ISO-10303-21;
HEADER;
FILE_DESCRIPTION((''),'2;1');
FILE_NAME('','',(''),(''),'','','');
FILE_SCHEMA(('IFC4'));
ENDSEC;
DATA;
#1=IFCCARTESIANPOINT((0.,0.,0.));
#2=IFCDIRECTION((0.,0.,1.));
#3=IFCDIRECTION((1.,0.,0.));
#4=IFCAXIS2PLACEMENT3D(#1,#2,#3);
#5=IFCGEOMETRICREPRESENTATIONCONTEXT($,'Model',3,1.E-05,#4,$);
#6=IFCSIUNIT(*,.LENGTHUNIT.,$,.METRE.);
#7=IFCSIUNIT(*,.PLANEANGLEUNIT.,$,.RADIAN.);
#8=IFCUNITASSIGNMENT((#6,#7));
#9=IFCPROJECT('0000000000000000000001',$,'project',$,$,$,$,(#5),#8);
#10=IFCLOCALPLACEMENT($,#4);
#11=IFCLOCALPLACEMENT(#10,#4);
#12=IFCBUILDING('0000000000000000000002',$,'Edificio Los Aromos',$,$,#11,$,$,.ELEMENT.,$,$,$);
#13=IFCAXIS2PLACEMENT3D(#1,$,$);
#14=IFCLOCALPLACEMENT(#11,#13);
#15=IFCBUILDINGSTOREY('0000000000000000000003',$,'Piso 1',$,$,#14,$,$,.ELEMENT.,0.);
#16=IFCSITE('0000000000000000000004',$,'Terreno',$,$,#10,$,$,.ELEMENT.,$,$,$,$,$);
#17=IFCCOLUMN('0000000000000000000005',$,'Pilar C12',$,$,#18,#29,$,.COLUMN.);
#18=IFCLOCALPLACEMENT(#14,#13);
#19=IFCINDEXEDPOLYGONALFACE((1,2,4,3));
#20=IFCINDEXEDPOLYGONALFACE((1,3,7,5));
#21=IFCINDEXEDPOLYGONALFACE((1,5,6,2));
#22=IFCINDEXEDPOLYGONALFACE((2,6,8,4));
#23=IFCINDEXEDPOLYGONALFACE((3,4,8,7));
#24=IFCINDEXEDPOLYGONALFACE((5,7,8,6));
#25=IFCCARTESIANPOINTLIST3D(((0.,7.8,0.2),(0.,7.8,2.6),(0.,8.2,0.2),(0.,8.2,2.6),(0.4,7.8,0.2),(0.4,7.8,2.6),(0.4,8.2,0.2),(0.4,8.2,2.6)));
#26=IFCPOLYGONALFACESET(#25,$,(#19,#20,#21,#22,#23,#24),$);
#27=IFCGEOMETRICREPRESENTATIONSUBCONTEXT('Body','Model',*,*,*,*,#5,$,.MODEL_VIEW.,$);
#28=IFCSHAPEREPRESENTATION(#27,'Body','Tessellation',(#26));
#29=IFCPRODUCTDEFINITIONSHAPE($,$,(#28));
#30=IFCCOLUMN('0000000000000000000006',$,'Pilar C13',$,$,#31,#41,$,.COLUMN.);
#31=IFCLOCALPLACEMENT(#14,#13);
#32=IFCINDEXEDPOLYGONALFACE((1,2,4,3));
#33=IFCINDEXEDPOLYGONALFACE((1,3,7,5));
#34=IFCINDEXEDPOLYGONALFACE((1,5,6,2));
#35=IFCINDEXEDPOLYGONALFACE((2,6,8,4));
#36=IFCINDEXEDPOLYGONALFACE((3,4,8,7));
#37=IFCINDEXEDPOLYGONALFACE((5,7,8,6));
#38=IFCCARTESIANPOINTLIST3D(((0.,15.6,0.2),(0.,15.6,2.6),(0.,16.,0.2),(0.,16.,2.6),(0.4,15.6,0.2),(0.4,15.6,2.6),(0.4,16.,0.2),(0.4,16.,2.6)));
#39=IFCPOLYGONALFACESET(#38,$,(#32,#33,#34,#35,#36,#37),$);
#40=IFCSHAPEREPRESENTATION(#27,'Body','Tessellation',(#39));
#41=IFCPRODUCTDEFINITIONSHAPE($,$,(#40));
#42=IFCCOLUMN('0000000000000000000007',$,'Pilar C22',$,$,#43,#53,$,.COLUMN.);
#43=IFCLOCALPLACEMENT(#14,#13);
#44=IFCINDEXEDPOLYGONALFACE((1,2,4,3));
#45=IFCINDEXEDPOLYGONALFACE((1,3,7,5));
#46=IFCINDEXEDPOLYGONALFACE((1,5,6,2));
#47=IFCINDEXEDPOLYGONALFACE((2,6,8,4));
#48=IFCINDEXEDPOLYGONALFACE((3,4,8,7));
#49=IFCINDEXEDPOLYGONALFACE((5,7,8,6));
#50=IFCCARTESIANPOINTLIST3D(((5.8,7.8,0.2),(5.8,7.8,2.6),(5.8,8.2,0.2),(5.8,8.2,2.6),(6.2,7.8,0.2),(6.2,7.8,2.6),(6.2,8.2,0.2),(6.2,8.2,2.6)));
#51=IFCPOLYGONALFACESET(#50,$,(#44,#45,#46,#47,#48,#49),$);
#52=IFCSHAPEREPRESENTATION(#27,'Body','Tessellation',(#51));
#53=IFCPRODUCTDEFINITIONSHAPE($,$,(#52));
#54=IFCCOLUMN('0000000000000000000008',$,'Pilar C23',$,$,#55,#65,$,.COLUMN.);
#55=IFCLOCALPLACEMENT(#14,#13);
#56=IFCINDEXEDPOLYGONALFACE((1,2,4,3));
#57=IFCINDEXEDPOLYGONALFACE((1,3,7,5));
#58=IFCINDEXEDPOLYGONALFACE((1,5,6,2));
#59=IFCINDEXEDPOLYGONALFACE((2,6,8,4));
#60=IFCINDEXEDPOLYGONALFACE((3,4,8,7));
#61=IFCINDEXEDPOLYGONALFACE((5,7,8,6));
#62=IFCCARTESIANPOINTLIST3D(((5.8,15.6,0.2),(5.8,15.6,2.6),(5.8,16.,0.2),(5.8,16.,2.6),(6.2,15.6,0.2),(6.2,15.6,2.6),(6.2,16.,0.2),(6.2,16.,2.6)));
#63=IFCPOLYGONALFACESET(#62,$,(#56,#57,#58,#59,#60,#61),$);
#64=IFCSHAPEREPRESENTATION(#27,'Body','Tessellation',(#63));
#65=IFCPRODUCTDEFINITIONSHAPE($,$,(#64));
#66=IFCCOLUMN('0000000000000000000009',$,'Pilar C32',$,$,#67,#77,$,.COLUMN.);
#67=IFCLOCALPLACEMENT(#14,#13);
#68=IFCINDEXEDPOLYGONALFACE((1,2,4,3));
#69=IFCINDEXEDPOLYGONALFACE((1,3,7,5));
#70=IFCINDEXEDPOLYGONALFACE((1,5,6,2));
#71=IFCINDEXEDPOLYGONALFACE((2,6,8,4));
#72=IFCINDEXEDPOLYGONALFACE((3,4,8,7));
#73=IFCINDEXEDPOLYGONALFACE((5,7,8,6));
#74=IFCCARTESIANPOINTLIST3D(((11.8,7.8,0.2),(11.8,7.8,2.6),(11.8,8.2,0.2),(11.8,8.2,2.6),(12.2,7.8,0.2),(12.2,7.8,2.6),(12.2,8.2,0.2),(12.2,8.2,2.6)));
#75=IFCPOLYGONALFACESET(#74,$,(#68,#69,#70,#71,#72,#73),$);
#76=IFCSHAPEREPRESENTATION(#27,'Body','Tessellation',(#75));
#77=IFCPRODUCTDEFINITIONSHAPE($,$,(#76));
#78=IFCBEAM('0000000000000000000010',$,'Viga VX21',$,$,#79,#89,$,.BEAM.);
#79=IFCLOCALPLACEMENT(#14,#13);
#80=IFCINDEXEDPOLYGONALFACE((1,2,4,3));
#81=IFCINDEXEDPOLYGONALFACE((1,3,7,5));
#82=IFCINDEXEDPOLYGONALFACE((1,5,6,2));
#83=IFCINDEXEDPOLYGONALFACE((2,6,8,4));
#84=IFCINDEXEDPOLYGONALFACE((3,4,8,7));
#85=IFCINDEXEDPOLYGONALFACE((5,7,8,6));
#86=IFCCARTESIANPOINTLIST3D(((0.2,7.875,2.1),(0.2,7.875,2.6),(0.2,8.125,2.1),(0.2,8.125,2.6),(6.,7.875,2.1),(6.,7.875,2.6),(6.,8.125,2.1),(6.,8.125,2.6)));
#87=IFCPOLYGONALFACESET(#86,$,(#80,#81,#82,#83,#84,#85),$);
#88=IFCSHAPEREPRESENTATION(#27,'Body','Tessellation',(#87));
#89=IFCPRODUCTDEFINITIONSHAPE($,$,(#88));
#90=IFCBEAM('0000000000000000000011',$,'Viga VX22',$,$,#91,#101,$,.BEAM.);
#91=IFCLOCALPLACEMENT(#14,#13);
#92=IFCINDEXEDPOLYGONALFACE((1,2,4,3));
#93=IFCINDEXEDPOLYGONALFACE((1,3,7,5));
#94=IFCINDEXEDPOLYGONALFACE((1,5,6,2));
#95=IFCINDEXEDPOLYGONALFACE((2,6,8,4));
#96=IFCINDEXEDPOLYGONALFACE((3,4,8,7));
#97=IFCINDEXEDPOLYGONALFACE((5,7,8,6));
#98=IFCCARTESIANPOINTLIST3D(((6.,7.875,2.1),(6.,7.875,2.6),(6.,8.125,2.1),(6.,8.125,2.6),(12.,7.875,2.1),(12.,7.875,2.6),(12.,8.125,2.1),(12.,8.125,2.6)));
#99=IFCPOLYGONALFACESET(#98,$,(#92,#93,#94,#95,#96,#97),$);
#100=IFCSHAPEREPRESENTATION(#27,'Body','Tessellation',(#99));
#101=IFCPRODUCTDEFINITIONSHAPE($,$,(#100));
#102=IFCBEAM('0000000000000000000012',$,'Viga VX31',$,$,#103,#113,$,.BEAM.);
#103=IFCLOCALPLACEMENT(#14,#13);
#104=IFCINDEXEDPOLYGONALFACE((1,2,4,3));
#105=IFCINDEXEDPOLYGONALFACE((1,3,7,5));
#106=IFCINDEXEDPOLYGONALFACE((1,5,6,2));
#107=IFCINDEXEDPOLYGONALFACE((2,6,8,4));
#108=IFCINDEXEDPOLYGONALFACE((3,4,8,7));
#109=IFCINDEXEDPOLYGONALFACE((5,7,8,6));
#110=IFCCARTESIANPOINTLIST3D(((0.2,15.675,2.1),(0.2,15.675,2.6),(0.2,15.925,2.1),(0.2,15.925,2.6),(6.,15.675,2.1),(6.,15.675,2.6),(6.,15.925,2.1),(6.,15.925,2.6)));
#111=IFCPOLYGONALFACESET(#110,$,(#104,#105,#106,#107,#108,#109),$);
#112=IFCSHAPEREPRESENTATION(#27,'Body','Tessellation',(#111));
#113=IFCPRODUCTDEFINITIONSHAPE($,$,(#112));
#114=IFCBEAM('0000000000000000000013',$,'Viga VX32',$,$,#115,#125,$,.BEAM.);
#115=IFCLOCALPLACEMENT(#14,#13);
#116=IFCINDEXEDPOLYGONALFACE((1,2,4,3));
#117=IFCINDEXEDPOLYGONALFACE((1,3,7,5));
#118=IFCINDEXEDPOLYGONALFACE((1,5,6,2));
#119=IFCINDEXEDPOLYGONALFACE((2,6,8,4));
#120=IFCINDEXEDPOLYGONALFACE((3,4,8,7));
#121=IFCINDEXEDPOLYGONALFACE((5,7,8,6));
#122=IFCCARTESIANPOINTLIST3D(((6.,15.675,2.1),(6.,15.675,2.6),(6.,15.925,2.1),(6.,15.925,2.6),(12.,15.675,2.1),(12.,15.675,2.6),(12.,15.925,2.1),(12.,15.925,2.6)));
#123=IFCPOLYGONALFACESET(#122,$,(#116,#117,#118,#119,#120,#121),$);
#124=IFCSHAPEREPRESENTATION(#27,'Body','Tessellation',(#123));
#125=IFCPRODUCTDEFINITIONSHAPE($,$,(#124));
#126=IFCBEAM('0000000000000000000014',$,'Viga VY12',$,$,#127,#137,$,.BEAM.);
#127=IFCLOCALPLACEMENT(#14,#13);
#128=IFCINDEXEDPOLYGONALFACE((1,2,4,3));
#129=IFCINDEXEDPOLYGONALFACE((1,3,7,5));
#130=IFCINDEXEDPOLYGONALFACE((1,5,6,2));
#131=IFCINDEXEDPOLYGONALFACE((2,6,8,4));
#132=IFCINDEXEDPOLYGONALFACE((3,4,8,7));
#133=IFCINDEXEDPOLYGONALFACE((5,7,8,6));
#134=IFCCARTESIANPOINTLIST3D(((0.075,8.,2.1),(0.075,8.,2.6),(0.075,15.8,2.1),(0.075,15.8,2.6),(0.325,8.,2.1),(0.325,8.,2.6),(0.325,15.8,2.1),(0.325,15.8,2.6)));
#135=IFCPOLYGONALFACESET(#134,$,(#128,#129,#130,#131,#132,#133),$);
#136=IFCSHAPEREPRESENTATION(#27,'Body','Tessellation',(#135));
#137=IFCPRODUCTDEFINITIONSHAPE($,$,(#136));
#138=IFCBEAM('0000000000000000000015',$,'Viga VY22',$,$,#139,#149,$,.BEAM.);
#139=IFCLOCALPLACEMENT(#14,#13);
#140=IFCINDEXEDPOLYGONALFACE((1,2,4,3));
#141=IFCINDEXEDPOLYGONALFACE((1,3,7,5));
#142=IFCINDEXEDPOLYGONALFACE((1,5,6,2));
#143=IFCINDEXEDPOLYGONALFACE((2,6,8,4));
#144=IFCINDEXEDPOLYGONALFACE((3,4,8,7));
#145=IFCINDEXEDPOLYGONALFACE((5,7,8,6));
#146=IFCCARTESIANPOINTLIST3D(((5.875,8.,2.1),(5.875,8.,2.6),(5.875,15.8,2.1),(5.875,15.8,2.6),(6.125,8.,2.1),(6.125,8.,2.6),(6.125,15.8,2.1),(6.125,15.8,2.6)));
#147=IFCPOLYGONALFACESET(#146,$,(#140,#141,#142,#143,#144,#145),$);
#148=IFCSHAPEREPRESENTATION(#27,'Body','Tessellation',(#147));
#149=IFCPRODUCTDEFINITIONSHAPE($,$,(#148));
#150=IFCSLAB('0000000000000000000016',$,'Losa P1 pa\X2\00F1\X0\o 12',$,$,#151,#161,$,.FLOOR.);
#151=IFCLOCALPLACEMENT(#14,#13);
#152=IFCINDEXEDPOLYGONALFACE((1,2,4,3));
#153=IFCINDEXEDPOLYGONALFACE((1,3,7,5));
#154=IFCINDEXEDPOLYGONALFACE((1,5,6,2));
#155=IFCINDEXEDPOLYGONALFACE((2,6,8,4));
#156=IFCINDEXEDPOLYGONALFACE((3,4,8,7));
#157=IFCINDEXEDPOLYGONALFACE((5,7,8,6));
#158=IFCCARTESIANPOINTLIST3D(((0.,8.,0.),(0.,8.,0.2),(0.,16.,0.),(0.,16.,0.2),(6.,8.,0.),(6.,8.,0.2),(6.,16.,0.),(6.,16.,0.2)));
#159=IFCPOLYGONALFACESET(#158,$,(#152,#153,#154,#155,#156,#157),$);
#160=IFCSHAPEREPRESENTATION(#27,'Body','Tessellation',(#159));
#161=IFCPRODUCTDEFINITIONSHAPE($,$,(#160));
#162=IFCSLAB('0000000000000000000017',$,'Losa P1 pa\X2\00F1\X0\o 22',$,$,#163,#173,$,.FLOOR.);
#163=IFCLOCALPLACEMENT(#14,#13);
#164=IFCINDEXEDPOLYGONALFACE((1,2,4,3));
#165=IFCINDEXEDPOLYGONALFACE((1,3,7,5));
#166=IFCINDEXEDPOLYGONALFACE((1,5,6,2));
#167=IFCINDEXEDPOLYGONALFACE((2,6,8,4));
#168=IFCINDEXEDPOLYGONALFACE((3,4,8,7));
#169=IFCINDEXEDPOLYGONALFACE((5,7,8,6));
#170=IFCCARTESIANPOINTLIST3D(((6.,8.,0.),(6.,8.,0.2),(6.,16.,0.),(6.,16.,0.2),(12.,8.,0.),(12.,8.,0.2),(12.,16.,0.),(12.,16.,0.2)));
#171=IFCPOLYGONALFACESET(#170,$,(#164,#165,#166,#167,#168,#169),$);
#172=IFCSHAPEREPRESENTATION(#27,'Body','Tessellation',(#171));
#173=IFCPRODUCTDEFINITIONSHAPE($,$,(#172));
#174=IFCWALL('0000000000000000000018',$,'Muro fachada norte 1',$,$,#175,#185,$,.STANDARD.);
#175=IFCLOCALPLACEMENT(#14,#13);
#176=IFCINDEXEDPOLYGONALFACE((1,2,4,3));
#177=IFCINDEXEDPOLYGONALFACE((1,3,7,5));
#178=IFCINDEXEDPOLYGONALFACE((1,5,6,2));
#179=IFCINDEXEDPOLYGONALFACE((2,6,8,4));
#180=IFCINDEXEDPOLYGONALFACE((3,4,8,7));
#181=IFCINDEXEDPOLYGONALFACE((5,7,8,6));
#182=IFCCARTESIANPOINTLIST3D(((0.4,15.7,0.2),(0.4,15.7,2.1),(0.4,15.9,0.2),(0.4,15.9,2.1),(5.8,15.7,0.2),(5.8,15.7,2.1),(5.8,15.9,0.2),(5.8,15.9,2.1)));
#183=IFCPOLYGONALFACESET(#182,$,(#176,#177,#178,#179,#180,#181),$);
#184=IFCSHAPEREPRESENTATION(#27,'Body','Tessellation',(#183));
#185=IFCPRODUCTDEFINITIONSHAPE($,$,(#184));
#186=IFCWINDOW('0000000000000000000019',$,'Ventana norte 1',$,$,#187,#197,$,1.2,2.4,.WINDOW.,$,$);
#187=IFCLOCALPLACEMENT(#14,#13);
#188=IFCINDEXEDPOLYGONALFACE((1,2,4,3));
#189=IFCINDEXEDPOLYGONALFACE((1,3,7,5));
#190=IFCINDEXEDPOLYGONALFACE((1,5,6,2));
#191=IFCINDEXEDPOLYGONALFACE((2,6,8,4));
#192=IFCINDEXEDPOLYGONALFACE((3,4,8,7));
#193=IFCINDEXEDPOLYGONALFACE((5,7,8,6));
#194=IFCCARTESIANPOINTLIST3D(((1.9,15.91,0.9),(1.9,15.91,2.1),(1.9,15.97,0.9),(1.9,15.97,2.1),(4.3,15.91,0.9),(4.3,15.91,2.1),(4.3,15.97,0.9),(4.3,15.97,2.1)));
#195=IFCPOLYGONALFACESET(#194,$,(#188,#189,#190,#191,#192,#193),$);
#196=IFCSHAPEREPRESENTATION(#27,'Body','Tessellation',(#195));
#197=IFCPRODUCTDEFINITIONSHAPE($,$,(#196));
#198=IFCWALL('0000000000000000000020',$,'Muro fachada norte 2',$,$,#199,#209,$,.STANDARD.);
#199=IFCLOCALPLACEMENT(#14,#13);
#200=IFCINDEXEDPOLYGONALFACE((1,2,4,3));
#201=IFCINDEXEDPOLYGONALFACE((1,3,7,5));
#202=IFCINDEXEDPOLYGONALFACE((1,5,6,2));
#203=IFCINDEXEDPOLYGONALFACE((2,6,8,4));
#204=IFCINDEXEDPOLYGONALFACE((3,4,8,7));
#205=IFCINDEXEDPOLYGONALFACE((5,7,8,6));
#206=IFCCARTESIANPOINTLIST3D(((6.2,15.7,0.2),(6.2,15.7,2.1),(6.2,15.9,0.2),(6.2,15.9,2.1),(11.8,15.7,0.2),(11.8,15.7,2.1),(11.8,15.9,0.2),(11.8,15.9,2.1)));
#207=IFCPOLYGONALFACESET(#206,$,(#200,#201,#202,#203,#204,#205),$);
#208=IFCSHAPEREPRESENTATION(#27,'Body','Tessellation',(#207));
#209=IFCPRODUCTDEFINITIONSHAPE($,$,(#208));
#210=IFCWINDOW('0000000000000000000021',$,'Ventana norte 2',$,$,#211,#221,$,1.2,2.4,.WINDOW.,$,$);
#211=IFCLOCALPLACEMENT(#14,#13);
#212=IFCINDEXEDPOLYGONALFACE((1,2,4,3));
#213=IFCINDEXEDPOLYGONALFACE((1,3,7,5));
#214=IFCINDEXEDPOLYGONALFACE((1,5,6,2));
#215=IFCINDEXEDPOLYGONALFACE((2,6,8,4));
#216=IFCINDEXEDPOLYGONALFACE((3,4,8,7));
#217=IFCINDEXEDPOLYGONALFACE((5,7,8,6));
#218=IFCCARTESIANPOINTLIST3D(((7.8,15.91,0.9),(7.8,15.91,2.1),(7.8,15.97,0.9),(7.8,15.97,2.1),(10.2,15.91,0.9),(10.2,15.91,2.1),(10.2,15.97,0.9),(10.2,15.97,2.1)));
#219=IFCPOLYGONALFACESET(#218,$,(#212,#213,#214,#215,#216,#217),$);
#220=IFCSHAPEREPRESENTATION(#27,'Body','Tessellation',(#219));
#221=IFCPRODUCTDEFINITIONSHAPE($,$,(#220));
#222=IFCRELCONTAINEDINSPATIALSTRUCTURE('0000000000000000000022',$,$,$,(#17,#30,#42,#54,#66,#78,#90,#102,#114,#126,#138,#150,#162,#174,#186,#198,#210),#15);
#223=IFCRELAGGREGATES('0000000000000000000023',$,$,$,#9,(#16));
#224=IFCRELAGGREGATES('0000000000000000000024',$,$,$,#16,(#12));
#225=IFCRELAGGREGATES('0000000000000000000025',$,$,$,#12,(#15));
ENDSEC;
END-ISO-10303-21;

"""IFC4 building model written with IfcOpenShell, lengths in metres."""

from ifc_helpers import new_model, si_unit, frame, frame_2d, origin, origin_with_axes, place, context, subcontext, project, spatial, rectangle, extrude, element, save


model = new_model("IFC4")

# Units and contexts
model_context = context("Model", 3, precision=1e-05, world=origin_with_axes())
body_context = subcontext(model_context, "Body", "Model", "MODEL_VIEW")
ifc_project = project(units=[si_unit("LENGTHUNIT", "METRE"), si_unit("PLANEANGLEUNIT", "RADIAN")], contexts=[model_context])

# Site, building, storey
site_placement = place(None, origin_with_axes())
site = spatial("IfcSite", under=ifc_project, at=site_placement, Name="Terreno", CompositionType="ELEMENT")
building_placement = place(site_placement, origin_with_axes())
building = spatial("IfcBuilding", under=site, at=building_placement, Name="Edificio Los Aromos", CompositionType="ELEMENT")
storey_placement = place(building_placement, origin())
storey = spatial("IfcBuildingStorey", under=building, at=storey_placement, Name="Piso 1", CompositionType="ELEMENT", Elevation=0.0)

# Columns
for number, where, name in (
    (1, (0.0, 7.8, 0.2), "Pilar C12"),
    (2, (0.0, 15.6, 0.2), "Pilar C13"),
    (3, (5.8, 7.8, 0.2), "Pilar C22"),
    (4, (5.8, 15.6, 0.2), "Pilar C23"),
    (5, (11.8, 7.8, 0.2), "Pilar C32"),
):
    element("IfcColumn", number, at=place(storey_placement, frame(where)), inside=storey, Name=name, PredefinedType="COLUMN", context=body_context, shape_type="SweptSolid", body=[
        extrude(rectangle(XDim=0.4, YDim=0.4, at=frame_2d((0.2, 0.2))), origin_with_axes(), (0.0, 0.0, 1.0), 2.4),
    ])

# Beams
beam_1_placement = place(storey_placement, frame((0.2, 7.875, 2.1)))
element("IfcBeam", 6, at=beam_1_placement, inside=storey, Name="Viga VX21", PredefinedType="BEAM", context=body_context, shape_type="SweptSolid", body=[
    extrude(rectangle(XDim=5.8, YDim=0.25, at=frame_2d((2.9, 0.125))), origin_with_axes(), (0.0, 0.0, 1.0), 0.5),
])
beam_2_placement = place(storey_placement, frame((6.0, 7.875, 2.1)))
element("IfcBeam", 7, at=beam_2_placement, inside=storey, Name="Viga VX22", PredefinedType="BEAM", context=body_context, shape_type="SweptSolid", body=[
    extrude(rectangle(XDim=6.0, YDim=0.25, at=frame_2d((3.0, 0.125))), origin_with_axes(), (0.0, 0.0, 1.0), 0.5),
])
beam_3_placement = place(storey_placement, frame((0.2, 15.675, 2.1)))
element("IfcBeam", 8, at=beam_3_placement, inside=storey, Name="Viga VX31", PredefinedType="BEAM", context=body_context, shape_type="SweptSolid", body=[
    extrude(rectangle(XDim=5.8, YDim=0.25, at=frame_2d((2.9, 0.125))), origin_with_axes(), (0.0, 0.0, 1.0), 0.5),
])
beam_4_placement = place(storey_placement, frame((6.0, 15.675, 2.1)))
element("IfcBeam", 9, at=beam_4_placement, inside=storey, Name="Viga VX32", PredefinedType="BEAM", context=body_context, shape_type="SweptSolid", body=[
    extrude(rectangle(XDim=6.0, YDim=0.25, at=frame_2d((3.0, 0.125))), origin_with_axes(), (0.0, 0.0, 1.0), 0.5),
])
for number, where, name in (
    (10, (0.075, 8.0, 2.1), "Viga VY12"),
    (11, (5.875, 8.0, 2.1), "Viga VY22"),
):
    element("IfcBeam", number, at=place(storey_placement, frame(where)), inside=storey, Name=name, PredefinedType="BEAM", context=body_context, shape_type="SweptSolid", body=[
        extrude(rectangle(XDim=0.25, YDim=7.8, at=frame_2d((0.125, 3.9))), origin_with_axes(), (0.0, 0.0, 1.0), 0.5),
    ])

# Slabs
for number, where, name in (
    (12, (0.0, 8.0, 0.0), "Losa P1 paño 12"),
    (13, (6.0, 8.0, 0.0), "Losa P1 paño 22"),
):
    element("IfcSlab", number, at=place(storey_placement, frame(where)), inside=storey, Name=name, PredefinedType="FLOOR", context=body_context, shape_type="SweptSolid", body=[
        extrude(rectangle(XDim=6.0, YDim=8.0, at=frame_2d((3.0, 4.0))), origin_with_axes(), (0.0, 0.0, 1.0), 0.2),
    ])

# Wall
wall_1_placement = place(storey_placement, frame((0.4, 15.7, 0.2)))
element("IfcWall", 14, at=wall_1_placement, inside=storey, Name="Muro fachada norte 1", PredefinedType="STANDARD", context=body_context, shape_type="SweptSolid", body=[
    extrude(rectangle(XDim=5.4, YDim=0.2, at=frame_2d((2.7, 0.1))), origin_with_axes(), (0.0, 0.0, 1.0), 1.9),
])

# Window
window_1_placement = place(storey_placement, frame((1.9, 15.91, 0.9)))
element("IfcWindow", 15, at=window_1_placement, inside=storey, Name="Ventana norte 1", OverallHeight=1.2, OverallWidth=2.4, PredefinedType="WINDOW", context=body_context, shape_type="SweptSolid", body=[
    extrude(rectangle(XDim=2.4, YDim=0.06, at=frame_2d((1.2, 0.03))), origin_with_axes(), (0.0, 0.0, 1.0), 1.2),
])

# Wall
wall_2_placement = place(storey_placement, frame((6.2, 15.7, 0.2)))
element("IfcWall", 16, at=wall_2_placement, inside=storey, Name="Muro fachada norte 2", PredefinedType="STANDARD", context=body_context, shape_type="SweptSolid", body=[
    extrude(rectangle(XDim=5.6, YDim=0.2, at=frame_2d((2.8, 0.1))), origin_with_axes(), (0.0, 0.0, 1.0), 1.9),
])

# Window
window_2_placement = place(storey_placement, frame((7.8, 15.91, 0.9)))
element("IfcWindow", 17, at=window_2_placement, inside=storey, Name="Ventana norte 2", OverallHeight=1.2, OverallWidth=2.4, PredefinedType="WINDOW", context=body_context, shape_type="SweptSolid", body=[
    extrude(rectangle(XDim=2.4, YDim=0.06, at=frame_2d((1.2, 0.03))), origin_with_axes(), (0.0, 0.0, 1.0), 1.2),
])

save(model, "model.ifc")
